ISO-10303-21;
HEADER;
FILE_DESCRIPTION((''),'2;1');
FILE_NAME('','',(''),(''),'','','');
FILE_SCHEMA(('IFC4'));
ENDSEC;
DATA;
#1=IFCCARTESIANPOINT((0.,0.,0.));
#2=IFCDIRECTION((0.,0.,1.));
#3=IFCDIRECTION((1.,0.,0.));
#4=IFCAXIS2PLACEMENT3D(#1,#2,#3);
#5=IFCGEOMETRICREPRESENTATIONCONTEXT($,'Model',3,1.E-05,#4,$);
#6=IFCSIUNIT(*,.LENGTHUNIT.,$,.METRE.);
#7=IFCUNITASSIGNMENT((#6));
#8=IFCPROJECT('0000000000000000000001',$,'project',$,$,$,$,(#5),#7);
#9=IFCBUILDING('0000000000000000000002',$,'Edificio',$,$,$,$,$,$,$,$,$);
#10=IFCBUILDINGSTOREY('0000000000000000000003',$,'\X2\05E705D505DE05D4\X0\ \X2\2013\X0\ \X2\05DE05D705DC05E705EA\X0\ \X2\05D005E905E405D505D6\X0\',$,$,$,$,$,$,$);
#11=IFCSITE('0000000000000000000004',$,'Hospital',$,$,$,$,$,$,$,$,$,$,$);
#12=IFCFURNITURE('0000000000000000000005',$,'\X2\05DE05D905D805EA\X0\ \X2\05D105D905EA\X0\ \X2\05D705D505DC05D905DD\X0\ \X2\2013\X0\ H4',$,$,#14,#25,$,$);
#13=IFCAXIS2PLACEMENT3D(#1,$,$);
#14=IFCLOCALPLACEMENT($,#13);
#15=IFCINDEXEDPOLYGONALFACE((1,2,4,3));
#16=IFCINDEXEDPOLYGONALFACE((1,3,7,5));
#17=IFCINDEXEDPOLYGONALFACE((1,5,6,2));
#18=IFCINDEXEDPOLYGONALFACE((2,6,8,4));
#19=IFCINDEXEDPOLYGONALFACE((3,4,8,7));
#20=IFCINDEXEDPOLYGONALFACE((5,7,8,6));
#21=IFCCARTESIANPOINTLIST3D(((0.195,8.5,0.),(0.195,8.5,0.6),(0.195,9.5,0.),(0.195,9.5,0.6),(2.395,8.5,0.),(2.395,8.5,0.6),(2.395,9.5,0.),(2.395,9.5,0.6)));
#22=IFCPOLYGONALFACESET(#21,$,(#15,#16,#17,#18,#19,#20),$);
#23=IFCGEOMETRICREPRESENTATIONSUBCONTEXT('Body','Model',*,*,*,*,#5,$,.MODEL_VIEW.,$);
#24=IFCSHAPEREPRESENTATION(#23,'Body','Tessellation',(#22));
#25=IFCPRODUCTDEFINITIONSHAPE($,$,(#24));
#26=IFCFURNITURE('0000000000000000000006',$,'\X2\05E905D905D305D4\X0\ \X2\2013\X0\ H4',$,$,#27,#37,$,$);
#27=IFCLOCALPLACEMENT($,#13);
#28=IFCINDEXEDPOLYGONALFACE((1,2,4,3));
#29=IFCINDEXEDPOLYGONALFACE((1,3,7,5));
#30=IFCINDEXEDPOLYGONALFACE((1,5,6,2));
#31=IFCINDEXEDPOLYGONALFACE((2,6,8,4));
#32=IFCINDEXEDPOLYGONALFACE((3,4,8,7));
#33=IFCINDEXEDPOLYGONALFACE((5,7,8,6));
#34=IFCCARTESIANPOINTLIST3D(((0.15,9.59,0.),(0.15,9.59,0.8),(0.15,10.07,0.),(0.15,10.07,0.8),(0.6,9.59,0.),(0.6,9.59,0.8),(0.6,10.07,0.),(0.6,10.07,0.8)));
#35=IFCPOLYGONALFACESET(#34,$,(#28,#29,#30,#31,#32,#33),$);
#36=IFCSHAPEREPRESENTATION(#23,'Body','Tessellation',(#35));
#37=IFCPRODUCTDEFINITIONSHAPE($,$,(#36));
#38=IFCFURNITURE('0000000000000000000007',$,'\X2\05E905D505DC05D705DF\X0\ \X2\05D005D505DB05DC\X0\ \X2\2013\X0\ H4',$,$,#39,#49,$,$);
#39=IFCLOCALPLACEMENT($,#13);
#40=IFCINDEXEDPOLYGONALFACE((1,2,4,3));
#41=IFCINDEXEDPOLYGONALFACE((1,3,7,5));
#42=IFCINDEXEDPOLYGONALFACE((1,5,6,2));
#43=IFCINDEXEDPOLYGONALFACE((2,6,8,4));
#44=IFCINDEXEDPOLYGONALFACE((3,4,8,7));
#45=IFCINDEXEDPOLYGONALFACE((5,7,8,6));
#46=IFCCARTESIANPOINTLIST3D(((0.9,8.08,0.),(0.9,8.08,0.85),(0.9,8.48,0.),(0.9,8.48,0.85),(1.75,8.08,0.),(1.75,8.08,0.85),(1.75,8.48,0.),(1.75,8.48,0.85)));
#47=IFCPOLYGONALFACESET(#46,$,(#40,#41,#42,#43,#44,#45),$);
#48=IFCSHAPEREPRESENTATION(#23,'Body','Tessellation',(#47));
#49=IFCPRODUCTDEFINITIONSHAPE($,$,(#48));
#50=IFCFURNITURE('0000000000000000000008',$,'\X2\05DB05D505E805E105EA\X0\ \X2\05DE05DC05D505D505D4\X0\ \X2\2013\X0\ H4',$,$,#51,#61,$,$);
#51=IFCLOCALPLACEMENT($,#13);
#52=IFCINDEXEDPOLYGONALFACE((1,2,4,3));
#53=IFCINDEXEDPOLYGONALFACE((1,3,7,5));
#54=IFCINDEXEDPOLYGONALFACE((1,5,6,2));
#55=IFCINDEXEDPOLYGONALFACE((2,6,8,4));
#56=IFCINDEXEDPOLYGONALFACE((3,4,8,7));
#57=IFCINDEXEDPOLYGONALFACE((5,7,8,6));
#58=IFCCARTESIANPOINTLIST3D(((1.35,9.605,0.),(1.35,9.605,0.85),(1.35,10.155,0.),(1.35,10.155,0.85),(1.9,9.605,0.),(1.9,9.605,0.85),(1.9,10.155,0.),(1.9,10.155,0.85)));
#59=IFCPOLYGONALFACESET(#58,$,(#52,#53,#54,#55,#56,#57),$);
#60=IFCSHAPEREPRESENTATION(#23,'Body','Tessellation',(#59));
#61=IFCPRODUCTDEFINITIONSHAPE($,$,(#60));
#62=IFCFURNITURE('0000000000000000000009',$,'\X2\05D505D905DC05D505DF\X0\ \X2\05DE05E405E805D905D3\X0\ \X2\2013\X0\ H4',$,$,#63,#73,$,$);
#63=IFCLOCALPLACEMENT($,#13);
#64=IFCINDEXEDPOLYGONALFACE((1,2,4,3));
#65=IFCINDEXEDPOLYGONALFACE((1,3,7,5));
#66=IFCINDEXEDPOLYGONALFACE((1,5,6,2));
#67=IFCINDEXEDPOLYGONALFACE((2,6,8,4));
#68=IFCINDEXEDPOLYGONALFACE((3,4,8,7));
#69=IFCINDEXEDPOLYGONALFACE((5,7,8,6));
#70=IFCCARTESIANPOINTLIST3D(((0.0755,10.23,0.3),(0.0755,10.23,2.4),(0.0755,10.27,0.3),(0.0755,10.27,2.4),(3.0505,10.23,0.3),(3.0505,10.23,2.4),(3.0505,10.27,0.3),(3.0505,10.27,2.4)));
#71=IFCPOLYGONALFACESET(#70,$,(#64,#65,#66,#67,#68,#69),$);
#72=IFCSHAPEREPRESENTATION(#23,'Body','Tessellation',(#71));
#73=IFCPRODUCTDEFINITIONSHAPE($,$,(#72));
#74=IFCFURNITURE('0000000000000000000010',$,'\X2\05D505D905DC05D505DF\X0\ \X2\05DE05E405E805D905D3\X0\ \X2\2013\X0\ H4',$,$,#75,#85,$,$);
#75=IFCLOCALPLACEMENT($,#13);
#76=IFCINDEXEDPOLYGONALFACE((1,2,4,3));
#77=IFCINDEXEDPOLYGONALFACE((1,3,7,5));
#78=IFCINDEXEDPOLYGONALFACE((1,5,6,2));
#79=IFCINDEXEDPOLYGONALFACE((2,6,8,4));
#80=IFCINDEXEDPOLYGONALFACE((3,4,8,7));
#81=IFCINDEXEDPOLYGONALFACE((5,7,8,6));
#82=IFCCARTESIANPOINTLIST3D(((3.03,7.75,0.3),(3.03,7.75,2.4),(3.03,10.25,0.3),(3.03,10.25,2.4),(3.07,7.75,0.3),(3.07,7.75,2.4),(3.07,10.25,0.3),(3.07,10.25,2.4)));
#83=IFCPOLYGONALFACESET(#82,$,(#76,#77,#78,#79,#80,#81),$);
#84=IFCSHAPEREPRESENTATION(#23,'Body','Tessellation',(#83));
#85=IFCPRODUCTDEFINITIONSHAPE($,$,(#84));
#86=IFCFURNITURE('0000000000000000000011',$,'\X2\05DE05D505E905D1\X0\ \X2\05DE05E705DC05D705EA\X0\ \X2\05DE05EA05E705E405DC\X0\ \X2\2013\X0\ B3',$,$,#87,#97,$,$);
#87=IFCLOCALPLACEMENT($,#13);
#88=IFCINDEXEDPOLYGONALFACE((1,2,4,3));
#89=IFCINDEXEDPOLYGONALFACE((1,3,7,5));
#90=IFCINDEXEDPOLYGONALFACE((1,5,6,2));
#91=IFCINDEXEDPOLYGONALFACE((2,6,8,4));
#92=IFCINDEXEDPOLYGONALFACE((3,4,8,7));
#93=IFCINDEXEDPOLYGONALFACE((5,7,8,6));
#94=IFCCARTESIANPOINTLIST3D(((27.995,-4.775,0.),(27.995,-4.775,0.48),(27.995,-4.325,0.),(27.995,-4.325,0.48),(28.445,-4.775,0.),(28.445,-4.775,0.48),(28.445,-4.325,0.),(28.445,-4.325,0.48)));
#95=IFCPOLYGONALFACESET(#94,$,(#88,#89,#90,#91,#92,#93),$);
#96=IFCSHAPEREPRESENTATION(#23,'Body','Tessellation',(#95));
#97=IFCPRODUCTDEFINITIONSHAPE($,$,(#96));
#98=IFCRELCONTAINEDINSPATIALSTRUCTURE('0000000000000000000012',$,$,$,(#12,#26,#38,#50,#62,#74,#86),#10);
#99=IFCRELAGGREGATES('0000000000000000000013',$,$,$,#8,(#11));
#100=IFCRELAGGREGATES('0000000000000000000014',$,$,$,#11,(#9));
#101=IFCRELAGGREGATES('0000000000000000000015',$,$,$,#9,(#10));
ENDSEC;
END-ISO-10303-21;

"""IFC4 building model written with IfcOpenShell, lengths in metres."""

from ifc_helpers import new_model, si_unit, frame, origin_with_axes, context, subcontext, project, spatial, line, indexed_curve, outline, extrude, element, save


model = new_model("IFC4")

# Units and contexts
model_context = context("Model", 3, precision=1e-05, world=origin_with_axes())
body_context = subcontext(model_context, "Body", "Model", "MODEL_VIEW")
ifc_project = project(units=[si_unit("LENGTHUNIT", "METRE")], contexts=[model_context])

# Site, building, storey
site = spatial("IfcSite", under=ifc_project, Name="Hospital")
building = spatial("IfcBuilding", under=site, Name="Edificio")
storey = spatial("IfcBuildingStorey", under=building, Name="קומה – מחלקת אשפוז")

# Furniture
element("IfcFurniture", 1, inside=storey, Name="מיטת בית חולים – H4", context=body_context, shape_type="SweptSolid", body=[
    extrude(outline(indexed_curve([(0.0, 0.0), (2.2, 0.0), (2.2, 1.0), (0.0, 1.0)], segments=[line(1, 2, 3, 4, 1)])), frame((0.195, 8.5, 0.0), z_axis=(0.0, 0.0, 1.0), x_axis=(1.0, 0.0, 0.0)), (0.0, 0.0, 1.0), 0.6),
])
element("IfcFurniture", 2, inside=storey, Name="שידה – H4", context=body_context, shape_type="SweptSolid", body=[
    extrude(outline(indexed_curve([(0.0, 0.0), (0.45, 0.0), (0.45, 0.48), (0.0, 0.48)], segments=[line(1, 2, 3, 4, 1)])), frame((0.15, 9.59, 0.0), z_axis=(0.0, 0.0, 1.0), x_axis=(1.0, 0.0, 0.0)), (0.0, 0.0, 1.0), 0.8),
])
element("IfcFurniture", 3, inside=storey, Name="שולחן אוכל – H4", context=body_context, shape_type="SweptSolid", body=[
    extrude(outline(indexed_curve([(0.0, 0.0), (0.85, 0.0), (0.85, 0.4), (0.0, 0.4)], segments=[line(1, 2, 3, 4, 1)])), frame((0.9, 8.08, 0.0), z_axis=(0.0, 0.0, 1.0), x_axis=(1.0, 0.0, 0.0)), (0.0, 0.0, 1.0), 0.85),
])
element("IfcFurniture", 4, inside=storey, Name="כורסת מלווה – H4", context=body_context, shape_type="SweptSolid", body=[
    extrude(outline(indexed_curve([(0.0, 0.0), (0.55, 0.0), (0.55, 0.55), (0.0, 0.55)], segments=[line(1, 2, 3, 4, 1)])), frame((1.35, 9.605, 0.0), z_axis=(0.0, 0.0, 1.0), x_axis=(1.0, 0.0, 0.0)), (0.0, 0.0, 1.0), 0.85),
])
element("IfcFurniture", 5, inside=storey, Name="וילון מפריד – H4", context=body_context, shape_type="SweptSolid", body=[
    extrude(outline(indexed_curve([(0.0, 0.0), (2.975, 0.0), (2.975, 0.04), (0.0, 0.04)], segments=[line(1, 2, 3, 4, 1)])), frame((0.0755, 10.23, 0.3), z_axis=(0.0, 0.0, 1.0), x_axis=(1.0, 0.0, 0.0)), (0.0, 0.0, 1.0), 2.1),
])
element("IfcFurniture", 6, inside=storey, Name="וילון מפריד – H4", context=body_context, shape_type="SweptSolid", body=[
    extrude(outline(indexed_curve([(0.0, 0.0), (0.04, 0.0), (0.04, 2.5), (0.0, 2.5)], segments=[line(1, 2, 3, 4, 1)])), frame((3.03, 7.75, 0.3), z_axis=(0.0, 0.0, 1.0), x_axis=(1.0, 0.0, 0.0)), (0.0, 0.0, 1.0), 2.1),
])
element("IfcFurniture", 7, inside=storey, Name="מושב מקלחת מתקפל – B3", context=body_context, shape_type="SweptSolid", body=[
    extrude(outline(indexed_curve([(0.0, 0.0), (0.45, 0.0), (0.45, 0.45), (0.0, 0.45)], segments=[line(1, 2, 3, 4, 1)])), frame((27.995, -4.775, 0.0), z_axis=(0.0, 0.0, 1.0), x_axis=(1.0, 0.0, 0.0)), (0.0, 0.0, 1.0), 0.48),
])

save(model, "model.ifc")
